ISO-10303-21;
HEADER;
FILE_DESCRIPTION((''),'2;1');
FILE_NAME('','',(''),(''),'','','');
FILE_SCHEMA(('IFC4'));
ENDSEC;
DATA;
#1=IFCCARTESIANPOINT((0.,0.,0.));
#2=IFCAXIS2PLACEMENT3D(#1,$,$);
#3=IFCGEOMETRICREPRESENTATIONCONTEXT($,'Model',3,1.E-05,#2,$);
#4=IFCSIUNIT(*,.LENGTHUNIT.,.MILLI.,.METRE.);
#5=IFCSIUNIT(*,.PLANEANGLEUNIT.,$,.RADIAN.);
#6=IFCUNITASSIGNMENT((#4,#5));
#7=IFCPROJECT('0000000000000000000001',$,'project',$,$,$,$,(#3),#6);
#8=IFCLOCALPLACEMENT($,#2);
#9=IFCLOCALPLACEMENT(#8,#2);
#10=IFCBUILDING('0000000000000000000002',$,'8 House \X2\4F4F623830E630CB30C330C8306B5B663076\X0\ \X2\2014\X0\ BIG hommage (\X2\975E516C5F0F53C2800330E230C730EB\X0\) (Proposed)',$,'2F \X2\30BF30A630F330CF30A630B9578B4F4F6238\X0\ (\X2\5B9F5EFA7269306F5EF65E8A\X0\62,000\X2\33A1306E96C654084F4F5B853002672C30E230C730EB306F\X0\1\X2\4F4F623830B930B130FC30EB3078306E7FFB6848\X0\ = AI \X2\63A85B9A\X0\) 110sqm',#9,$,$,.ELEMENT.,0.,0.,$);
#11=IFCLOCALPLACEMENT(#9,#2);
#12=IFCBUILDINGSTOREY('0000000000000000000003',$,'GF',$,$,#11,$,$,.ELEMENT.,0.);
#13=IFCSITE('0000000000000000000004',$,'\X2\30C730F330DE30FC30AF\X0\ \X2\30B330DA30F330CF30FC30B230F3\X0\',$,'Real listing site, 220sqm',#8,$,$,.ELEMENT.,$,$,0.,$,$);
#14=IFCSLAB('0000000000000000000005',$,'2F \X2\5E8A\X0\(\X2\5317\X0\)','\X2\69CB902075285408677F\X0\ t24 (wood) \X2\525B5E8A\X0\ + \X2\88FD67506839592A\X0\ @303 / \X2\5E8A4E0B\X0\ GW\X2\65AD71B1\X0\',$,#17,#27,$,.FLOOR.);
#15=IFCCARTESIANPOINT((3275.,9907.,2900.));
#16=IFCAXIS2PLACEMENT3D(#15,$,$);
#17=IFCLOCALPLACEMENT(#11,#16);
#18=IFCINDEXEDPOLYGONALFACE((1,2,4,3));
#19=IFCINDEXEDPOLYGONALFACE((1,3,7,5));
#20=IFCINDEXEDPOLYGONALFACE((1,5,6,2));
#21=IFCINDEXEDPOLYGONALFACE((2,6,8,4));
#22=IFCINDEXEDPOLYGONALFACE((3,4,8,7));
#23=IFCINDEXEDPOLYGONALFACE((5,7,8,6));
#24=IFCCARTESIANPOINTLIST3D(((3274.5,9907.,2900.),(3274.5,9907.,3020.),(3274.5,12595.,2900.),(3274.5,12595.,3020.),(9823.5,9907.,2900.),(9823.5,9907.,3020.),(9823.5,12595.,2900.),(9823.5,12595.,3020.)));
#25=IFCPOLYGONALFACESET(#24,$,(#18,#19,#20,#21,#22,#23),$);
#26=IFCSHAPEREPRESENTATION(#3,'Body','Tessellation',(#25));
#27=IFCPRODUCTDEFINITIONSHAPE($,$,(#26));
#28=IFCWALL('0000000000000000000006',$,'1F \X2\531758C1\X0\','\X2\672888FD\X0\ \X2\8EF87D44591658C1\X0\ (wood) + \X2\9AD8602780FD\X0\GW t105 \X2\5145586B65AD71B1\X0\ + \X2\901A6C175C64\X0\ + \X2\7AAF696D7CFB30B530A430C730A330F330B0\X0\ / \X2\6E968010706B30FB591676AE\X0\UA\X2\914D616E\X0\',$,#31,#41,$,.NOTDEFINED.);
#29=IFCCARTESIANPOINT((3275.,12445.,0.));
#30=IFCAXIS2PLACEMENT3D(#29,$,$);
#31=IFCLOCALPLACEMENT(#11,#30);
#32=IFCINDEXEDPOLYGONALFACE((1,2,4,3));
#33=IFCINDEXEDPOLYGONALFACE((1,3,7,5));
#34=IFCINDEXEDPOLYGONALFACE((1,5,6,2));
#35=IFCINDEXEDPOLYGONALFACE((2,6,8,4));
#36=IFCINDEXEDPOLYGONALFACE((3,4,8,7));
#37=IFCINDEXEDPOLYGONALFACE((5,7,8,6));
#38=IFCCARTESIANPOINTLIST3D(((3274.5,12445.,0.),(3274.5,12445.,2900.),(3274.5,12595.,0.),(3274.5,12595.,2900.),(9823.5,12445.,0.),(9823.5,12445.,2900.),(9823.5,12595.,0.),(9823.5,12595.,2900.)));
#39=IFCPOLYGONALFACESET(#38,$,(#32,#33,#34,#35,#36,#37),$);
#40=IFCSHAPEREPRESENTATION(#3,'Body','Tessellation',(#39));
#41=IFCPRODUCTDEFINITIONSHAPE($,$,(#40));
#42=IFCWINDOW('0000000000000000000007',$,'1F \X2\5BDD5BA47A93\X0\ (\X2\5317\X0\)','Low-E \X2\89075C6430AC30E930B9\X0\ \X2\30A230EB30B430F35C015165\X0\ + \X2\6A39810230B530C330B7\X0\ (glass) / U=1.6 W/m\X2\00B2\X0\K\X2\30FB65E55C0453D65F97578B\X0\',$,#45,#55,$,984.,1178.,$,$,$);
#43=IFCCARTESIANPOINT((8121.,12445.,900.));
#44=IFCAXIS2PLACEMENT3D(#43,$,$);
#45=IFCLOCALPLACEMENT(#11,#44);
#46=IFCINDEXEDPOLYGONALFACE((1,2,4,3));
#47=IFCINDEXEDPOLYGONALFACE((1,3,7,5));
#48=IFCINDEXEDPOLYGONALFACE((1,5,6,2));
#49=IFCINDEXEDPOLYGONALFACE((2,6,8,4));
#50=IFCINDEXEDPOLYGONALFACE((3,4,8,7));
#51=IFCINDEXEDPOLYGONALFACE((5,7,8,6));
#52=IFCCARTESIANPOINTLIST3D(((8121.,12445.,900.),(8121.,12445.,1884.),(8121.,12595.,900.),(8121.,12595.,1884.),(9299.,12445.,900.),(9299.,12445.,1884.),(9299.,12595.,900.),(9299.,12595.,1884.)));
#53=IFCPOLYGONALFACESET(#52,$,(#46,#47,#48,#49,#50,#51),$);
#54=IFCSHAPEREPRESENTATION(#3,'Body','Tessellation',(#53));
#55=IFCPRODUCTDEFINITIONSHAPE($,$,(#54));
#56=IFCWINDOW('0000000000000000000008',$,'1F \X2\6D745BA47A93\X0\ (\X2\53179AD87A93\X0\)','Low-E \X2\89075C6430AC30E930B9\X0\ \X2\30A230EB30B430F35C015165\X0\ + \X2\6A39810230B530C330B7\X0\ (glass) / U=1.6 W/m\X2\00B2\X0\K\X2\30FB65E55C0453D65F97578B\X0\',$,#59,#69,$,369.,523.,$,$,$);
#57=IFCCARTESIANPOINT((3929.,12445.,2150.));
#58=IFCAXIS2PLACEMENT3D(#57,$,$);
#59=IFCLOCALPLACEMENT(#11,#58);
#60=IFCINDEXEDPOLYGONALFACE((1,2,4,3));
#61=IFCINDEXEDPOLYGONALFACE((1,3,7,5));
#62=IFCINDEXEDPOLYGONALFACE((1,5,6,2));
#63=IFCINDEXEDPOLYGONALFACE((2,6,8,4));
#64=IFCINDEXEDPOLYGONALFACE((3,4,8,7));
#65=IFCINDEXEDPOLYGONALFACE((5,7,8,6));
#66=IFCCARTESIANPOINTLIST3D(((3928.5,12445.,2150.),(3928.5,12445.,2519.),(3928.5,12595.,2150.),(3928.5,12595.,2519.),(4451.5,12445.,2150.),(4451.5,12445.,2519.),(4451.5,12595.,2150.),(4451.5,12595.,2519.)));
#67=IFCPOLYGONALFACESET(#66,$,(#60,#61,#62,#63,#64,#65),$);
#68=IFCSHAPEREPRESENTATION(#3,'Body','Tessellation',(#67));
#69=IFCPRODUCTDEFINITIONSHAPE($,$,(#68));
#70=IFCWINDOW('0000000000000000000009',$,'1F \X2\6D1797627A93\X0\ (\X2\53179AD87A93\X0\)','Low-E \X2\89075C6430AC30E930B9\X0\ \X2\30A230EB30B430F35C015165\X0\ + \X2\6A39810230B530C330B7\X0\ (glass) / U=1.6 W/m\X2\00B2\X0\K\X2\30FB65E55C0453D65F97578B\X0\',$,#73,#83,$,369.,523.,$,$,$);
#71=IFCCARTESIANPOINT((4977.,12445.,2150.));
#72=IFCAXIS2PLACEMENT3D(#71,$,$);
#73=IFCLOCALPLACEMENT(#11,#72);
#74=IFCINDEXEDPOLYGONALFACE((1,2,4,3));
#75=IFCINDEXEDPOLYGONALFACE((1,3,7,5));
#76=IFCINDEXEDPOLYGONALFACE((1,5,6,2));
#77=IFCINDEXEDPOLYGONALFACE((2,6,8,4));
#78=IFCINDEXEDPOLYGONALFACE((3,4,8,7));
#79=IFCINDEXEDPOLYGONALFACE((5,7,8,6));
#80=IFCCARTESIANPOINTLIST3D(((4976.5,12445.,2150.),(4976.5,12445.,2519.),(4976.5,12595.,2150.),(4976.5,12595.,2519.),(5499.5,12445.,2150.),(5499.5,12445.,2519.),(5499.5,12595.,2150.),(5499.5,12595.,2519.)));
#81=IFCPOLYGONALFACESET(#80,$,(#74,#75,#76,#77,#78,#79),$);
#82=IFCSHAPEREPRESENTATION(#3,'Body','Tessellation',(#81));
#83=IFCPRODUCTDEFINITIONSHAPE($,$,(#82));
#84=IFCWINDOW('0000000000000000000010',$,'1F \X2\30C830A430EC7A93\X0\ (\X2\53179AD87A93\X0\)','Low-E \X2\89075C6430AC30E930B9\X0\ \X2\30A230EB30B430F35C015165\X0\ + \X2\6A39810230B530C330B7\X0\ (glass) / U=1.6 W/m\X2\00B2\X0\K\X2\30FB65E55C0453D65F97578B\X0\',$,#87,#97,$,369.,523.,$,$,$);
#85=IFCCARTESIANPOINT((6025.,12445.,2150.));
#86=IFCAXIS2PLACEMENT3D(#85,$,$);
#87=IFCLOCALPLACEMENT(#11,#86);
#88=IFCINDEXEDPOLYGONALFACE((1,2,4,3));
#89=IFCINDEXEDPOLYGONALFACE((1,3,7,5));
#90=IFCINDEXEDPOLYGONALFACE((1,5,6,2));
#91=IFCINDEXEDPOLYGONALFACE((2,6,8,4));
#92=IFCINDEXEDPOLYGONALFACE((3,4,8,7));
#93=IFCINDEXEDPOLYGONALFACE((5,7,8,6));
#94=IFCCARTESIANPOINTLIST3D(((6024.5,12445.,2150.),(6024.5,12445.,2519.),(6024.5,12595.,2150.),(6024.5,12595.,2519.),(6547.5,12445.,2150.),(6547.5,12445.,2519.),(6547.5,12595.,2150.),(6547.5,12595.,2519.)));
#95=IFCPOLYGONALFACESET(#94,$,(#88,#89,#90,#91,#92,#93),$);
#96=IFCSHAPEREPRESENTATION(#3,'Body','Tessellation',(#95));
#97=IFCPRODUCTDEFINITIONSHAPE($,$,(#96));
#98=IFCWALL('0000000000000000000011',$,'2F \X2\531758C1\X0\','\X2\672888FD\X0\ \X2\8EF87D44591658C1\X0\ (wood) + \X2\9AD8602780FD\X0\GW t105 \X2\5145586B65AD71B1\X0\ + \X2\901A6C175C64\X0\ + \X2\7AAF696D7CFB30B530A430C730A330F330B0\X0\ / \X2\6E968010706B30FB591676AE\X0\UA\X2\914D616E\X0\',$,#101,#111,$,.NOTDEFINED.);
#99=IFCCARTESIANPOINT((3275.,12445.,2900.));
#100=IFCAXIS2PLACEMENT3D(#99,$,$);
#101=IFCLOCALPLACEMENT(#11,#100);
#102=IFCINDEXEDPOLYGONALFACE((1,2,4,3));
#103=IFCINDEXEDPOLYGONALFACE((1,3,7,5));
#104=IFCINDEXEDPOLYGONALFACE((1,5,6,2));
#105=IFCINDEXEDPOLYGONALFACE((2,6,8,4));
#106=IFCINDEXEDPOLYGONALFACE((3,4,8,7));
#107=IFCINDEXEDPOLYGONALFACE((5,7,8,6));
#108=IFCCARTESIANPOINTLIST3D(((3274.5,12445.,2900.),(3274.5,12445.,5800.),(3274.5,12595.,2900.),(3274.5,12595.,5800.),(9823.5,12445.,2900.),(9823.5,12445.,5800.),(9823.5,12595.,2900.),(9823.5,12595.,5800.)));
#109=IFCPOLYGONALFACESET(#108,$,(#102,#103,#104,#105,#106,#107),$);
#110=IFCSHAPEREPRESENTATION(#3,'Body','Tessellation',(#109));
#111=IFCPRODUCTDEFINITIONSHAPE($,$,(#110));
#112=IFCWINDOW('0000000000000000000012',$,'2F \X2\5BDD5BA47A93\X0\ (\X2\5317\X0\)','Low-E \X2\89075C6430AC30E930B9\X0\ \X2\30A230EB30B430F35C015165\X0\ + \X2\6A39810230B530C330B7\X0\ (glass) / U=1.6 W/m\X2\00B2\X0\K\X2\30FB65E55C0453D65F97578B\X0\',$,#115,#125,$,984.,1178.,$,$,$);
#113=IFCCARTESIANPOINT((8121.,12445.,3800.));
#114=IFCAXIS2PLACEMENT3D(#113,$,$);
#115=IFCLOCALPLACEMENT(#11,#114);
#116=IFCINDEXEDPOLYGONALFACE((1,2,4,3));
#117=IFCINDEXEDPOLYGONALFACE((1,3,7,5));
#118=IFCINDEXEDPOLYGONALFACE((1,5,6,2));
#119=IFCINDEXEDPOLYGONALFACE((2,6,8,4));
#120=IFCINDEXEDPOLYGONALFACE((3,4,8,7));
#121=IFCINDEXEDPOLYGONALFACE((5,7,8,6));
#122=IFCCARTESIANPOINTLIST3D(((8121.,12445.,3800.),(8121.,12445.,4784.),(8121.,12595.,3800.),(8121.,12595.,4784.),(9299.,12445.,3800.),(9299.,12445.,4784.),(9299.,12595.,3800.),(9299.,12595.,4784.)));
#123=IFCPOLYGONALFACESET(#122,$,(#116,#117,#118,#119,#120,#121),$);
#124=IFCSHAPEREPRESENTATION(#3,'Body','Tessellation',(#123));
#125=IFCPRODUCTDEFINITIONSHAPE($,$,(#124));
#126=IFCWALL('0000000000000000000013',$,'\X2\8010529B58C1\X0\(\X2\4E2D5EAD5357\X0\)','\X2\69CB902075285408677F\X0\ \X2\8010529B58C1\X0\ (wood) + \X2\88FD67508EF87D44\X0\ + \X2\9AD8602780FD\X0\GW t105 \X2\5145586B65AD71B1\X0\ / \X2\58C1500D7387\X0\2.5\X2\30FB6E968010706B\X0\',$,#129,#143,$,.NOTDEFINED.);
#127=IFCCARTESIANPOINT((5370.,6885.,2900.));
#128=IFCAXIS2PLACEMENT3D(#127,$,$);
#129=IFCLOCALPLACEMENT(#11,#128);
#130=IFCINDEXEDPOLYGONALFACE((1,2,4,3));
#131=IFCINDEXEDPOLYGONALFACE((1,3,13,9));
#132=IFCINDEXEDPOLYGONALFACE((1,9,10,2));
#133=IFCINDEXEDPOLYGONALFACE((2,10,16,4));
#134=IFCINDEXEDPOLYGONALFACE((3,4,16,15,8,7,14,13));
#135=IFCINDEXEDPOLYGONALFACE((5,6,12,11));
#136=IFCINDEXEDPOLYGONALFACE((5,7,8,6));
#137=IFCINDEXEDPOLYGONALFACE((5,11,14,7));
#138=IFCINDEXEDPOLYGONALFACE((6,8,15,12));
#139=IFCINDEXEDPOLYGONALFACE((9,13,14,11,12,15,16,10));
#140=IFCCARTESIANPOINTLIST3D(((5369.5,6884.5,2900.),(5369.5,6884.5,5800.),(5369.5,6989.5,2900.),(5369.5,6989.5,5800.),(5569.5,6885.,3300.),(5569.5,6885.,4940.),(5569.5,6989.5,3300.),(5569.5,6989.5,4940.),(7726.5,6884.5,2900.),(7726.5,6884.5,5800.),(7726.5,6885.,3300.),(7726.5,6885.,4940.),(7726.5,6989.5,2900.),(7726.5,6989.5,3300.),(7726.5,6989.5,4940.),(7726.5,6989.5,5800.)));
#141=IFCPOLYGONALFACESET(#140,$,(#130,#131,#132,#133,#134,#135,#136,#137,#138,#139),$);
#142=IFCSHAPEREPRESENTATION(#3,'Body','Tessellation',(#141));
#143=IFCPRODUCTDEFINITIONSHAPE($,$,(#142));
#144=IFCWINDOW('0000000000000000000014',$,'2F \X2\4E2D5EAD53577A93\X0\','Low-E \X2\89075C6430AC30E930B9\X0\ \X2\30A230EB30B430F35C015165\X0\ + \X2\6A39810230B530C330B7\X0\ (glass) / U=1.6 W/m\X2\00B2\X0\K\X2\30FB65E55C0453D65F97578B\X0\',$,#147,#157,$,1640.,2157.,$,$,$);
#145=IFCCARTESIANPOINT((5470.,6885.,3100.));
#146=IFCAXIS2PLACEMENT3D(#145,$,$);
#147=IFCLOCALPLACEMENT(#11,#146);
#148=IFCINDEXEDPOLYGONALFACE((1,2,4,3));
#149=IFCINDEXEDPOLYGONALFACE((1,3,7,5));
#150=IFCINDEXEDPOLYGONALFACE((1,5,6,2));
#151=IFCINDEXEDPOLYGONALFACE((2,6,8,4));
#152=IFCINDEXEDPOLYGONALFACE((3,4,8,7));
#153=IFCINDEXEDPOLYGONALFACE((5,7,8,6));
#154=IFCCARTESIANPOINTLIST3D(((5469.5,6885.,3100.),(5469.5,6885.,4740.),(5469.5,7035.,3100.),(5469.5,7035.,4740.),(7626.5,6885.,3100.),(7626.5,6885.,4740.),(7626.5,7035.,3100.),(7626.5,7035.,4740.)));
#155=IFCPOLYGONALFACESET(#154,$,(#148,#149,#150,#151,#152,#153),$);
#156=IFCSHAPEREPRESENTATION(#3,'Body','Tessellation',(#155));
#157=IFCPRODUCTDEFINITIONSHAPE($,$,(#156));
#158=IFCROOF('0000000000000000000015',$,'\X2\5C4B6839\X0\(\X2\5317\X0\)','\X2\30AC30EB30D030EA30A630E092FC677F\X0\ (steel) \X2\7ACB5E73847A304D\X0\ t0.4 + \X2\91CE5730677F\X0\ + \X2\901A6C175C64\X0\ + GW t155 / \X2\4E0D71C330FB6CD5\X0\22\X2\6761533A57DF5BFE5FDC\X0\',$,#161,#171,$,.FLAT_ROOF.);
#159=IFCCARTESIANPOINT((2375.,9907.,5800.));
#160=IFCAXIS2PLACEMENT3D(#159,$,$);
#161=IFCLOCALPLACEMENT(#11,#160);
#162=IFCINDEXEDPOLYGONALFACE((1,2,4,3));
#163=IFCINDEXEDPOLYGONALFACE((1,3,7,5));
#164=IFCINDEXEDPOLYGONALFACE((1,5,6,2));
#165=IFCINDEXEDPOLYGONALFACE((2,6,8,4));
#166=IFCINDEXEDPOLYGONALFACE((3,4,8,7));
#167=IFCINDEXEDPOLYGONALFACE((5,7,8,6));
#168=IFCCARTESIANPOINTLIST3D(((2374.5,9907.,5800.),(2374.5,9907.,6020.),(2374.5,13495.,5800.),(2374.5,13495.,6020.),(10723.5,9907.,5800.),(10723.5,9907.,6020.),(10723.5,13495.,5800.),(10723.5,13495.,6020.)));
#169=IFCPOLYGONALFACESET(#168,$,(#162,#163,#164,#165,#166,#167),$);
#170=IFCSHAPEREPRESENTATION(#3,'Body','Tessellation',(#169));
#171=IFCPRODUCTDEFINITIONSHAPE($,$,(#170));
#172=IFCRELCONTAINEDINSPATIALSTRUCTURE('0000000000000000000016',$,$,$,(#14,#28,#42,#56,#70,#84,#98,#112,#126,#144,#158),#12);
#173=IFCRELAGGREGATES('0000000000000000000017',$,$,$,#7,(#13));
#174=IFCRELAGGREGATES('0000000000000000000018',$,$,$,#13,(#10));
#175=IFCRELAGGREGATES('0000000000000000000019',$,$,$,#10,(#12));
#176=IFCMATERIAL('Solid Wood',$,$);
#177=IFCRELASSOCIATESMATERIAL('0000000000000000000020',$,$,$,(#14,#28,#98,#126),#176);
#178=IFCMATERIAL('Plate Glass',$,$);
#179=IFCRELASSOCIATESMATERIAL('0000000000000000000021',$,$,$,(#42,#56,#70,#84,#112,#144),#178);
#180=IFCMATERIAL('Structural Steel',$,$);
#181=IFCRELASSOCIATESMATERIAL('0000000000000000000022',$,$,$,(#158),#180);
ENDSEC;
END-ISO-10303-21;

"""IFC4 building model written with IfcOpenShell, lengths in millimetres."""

from ifc_helpers import new_model, si_unit, frame, frame_2d, origin, place, context, project, spatial, rectangle, extrude, material, element, fill, save


model = new_model("IFC4")

# Units and contexts
model_context = context("Model", 3, precision=1e-05, world=origin())
ifc_project = project(units=[si_unit("LENGTHUNIT", "METRE", prefix="MILLI"), si_unit("PLANEANGLEUNIT", "RADIAN")], contexts=[model_context])

# Site, building, storey
site_placement = place(None, origin())
site = spatial("IfcSite", under=ifc_project, at=site_placement, Name="デンマーク コペンハーゲン", ObjectType="Real listing site, 220sqm", CompositionType="ELEMENT", RefElevation=0.0)
building_placement = place(site_placement, origin())
building = spatial("IfcBuilding", under=site, at=building_placement, Name="8 House 住戸ユニットに学ぶ — BIG hommage (非公式参考モデル) (Proposed)", ObjectType="2F タウンハウス型住戸 (実建物は延床62,000㎡の集合住宅。本モデルは1住戸スケールへの翻案 = AI 推定) 110sqm", CompositionType="ELEMENT", ElevationOfRefHeight=0.0, ElevationOfTerrain=0.0)
storey_placement = place(building_placement, origin())
storey = spatial("IfcBuildingStorey", under=building, at=storey_placement, Name="GF", CompositionType="ELEMENT", Elevation=0.0)

# Slab
ifc_material_1 = material(Name="Solid Wood")
slab_1_placement = place(storey_placement, frame((3275.0, 9907.0, 2900.0)))
element("IfcSlab", 1, at=slab_1_placement, inside=storey, material=ifc_material_1, Name="2F 床(北)", Description="構造用合板 t24 (wood) 剛床 + 製材根太 @303 / 床下 GW断熱", PredefinedType="FLOOR", context=model_context, shape_type="SweptSolid", body=[
    extrude(rectangle(XDim=6549.0, YDim=2688.0, at=frame_2d((3274.0, 1344.0))), frame((3275.0, 9907.0, 2900.0)), (0.0, 0.0, 1.0), 120.0),
])

# Wall, openings, windows
wall_1_placement = place(storey_placement, frame((3275.0, 12445.0, 0.0)))
wall_1 = element("IfcWall", 2, at=wall_1_placement, inside=storey, material=ifc_material_1, Name="1F 北壁", Description="木製 軸組外壁 (wood) + 高性能GW t105 充填断熱 + 通気層 + 窯業系サイディング / 準耐火・外皮UA配慮", PredefinedType="NOTDEFINED", context=model_context, shape_type="SweptSolid", body=[
    extrude(rectangle(XDim=6549.0, YDim=150.0, at=frame_2d((3274.0, 75.0))), frame((3275.0, 12445.0, 0.0)), (0.0, 0.0, 1.0), 2900.0),
])
opening_1_placement = place(storey_placement, frame((8121.0, 12445.0, 900.0)))
opening_1 = element("IfcOpeningElement", 3, at=opening_1_placement, cuts=wall_1, PredefinedType="NOTDEFINED", context=model_context, shape_type="SweptSolid", body=[
    extrude(rectangle(XDim=1178.0, YDim=150.0, at=frame_2d((589.0, 75.0))), frame((8121.0, 12445.0, 900.0)), (0.0, 0.0, 1.0), 984.0),
])
opening_2_placement = place(storey_placement, frame((3929.0, 12445.0, 2150.0)))
opening_2 = element("IfcOpeningElement", 4, at=opening_2_placement, cuts=wall_1, PredefinedType="NOTDEFINED", context=model_context, shape_type="SweptSolid", body=[
    extrude(rectangle(XDim=523.0, YDim=150.0, at=frame_2d((261.0, 75.0))), frame((3929.0, 12445.0, 2150.0)), (0.0, 0.0, 1.0), 369.0),
])
opening_3_placement = place(storey_placement, frame((4977.0, 12445.0, 2150.0)))
opening_3 = element("IfcOpeningElement", 5, at=opening_3_placement, cuts=wall_1, PredefinedType="NOTDEFINED", context=model_context, shape_type="SweptSolid", body=[
    extrude(rectangle(XDim=523.0, YDim=150.0, at=frame_2d((261.0, 75.0))), frame((4977.0, 12445.0, 2150.0)), (0.0, 0.0, 1.0), 369.0),
])
opening_4_placement = place(storey_placement, frame((6025.0, 12445.0, 2150.0)))
opening_4 = element("IfcOpeningElement", 6, at=opening_4_placement, cuts=wall_1, PredefinedType="NOTDEFINED", context=model_context, shape_type="SweptSolid", body=[
    extrude(rectangle(XDim=523.0, YDim=150.0, at=frame_2d((261.0, 75.0))), frame((6025.0, 12445.0, 2150.0)), (0.0, 0.0, 1.0), 369.0),
])
ifc_material_2 = material(Name="Plate Glass")
window_1_placement = place(storey_placement, frame((8121.0, 12445.0, 900.0)))
window_1 = element("IfcWindow", 7, at=window_1_placement, inside=storey, material=ifc_material_2, Name="1F 寝室窓 (北)", Description="Low-E 複層ガラス アルゴン封入 + 樹脂サッシ (glass) / U=1.6 W/m²K・日射取得型", OverallHeight=984.0, OverallWidth=1178.0, context=model_context, shape_type="SweptSolid", body=[
    extrude(rectangle(XDim=1178.0, YDim=150.0, at=frame_2d((589.0, 75.0))), frame((8121.0, 12445.0, 900.0)), (0.0, 0.0, 1.0), 984.0),
])
fill(opening_1, window_1)
window_2_placement = place(storey_placement, frame((3929.0, 12445.0, 2150.0)))
window_2 = element("IfcWindow", 8, at=window_2_placement, inside=storey, material=ifc_material_2, Name="1F 浴室窓 (北高窓)", Description="Low-E 複層ガラス アルゴン封入 + 樹脂サッシ (glass) / U=1.6 W/m²K・日射取得型", OverallHeight=369.0, OverallWidth=523.0, context=model_context, shape_type="SweptSolid", body=[
    extrude(rectangle(XDim=523.0, YDim=150.0, at=frame_2d((261.0, 75.0))), frame((3929.0, 12445.0, 2150.0)), (0.0, 0.0, 1.0), 369.0),
])
fill(opening_2, window_2)
window_3_placement = place(storey_placement, frame((4977.0, 12445.0, 2150.0)))
window_3 = element("IfcWindow", 9, at=window_3_placement, inside=storey, material=ifc_material_2, Name="1F 洗面窓 (北高窓)", Description="Low-E 複層ガラス アルゴン封入 + 樹脂サッシ (glass) / U=1.6 W/m²K・日射取得型", OverallHeight=369.0, OverallWidth=523.0, context=model_context, shape_type="SweptSolid", body=[
    extrude(rectangle(XDim=523.0, YDim=150.0, at=frame_2d((261.0, 75.0))), frame((4977.0, 12445.0, 2150.0)), (0.0, 0.0, 1.0), 369.0),
])
fill(opening_3, window_3)
window_4_placement = place(storey_placement, frame((6025.0, 12445.0, 2150.0)))
window_4 = element("IfcWindow", 10, at=window_4_placement, inside=storey, material=ifc_material_2, Name="1F トイレ窓 (北高窓)", Description="Low-E 複層ガラス アルゴン封入 + 樹脂サッシ (glass) / U=1.6 W/m²K・日射取得型", OverallHeight=369.0, OverallWidth=523.0, context=model_context, shape_type="SweptSolid", body=[
    extrude(rectangle(XDim=523.0, YDim=150.0, at=frame_2d((261.0, 75.0))), frame((6025.0, 12445.0, 2150.0)), (0.0, 0.0, 1.0), 369.0),
])
fill(opening_4, window_4)

# Walls, openings, windows
wall_2_placement = place(storey_placement, frame((3275.0, 12445.0, 2900.0)))
wall_2 = element("IfcWall", 11, at=wall_2_placement, inside=storey, material=ifc_material_1, Name="2F 北壁", Description="木製 軸組外壁 (wood) + 高性能GW t105 充填断熱 + 通気層 + 窯業系サイディング / 準耐火・外皮UA配慮", PredefinedType="NOTDEFINED", context=model_context, shape_type="SweptSolid", body=[
    extrude(rectangle(XDim=6549.0, YDim=150.0, at=frame_2d((3274.0, 75.0))), frame((3275.0, 12445.0, 2900.0)), (0.0, 0.0, 1.0), 2900.0),
])
opening_5_placement = place(storey_placement, frame((8121.0, 12445.0, 3800.0)))
opening_5 = element("IfcOpeningElement", 12, at=opening_5_placement, cuts=wall_2, PredefinedType="NOTDEFINED", context=model_context, shape_type="SweptSolid", body=[
    extrude(rectangle(XDim=1178.0, YDim=150.0, at=frame_2d((589.0, 75.0))), frame((8121.0, 12445.0, 3800.0)), (0.0, 0.0, 1.0), 984.0),
])
window_5_placement = place(storey_placement, frame((8121.0, 12445.0, 3800.0)))
window_5 = element("IfcWindow", 13, at=window_5_placement, inside=storey, material=ifc_material_2, Name="2F 寝室窓 (北)", Description="Low-E 複層ガラス アルゴン封入 + 樹脂サッシ (glass) / U=1.6 W/m²K・日射取得型", OverallHeight=984.0, OverallWidth=1178.0, context=model_context, shape_type="SweptSolid", body=[
    extrude(rectangle(XDim=1178.0, YDim=150.0, at=frame_2d((589.0, 75.0))), frame((8121.0, 12445.0, 3800.0)), (0.0, 0.0, 1.0), 984.0),
])
fill(opening_5, window_5)
wall_3_placement = place(storey_placement, frame((5370.0, 6885.0, 2900.0)))
wall_3 = element("IfcWall", 14, at=wall_3_placement, inside=storey, material=ifc_material_1, Name="耐力壁(中庭南)", Description="構造用合板 耐力壁 (wood) + 製材軸組 + 高性能GW t105 充填断熱 / 壁倍率2.5・準耐火", PredefinedType="NOTDEFINED", context=model_context, shape_type="SweptSolid", body=[
    extrude(rectangle(XDim=2357.0, YDim=105.0, at=frame_2d((1178.0, 52.0))), frame((5370.0, 6885.0, 2900.0)), (0.0, 0.0, 1.0), 2900.0),
])
opening_6_placement = place(storey_placement, frame((5470.0, 6885.0, 3100.0)))
opening_6 = element("IfcOpeningElement", 15, at=opening_6_placement, cuts=wall_3, PredefinedType="NOTDEFINED", context=model_context, shape_type="SweptSolid", body=[
    extrude(rectangle(XDim=2157.0, YDim=150.0, at=frame_2d((1078.0, 75.0))), frame((5470.0, 6885.0, 3100.0)), (0.0, 0.0, 1.0), 1640.0),
])
window_6_placement = place(storey_placement, frame((5470.0, 6885.0, 3100.0)))
window_6 = element("IfcWindow", 16, at=window_6_placement, inside=storey, material=ifc_material_2, Name="2F 中庭南窓", Description="Low-E 複層ガラス アルゴン封入 + 樹脂サッシ (glass) / U=1.6 W/m²K・日射取得型", OverallHeight=1640.0, OverallWidth=2157.0, context=model_context, shape_type="SweptSolid", body=[
    extrude(rectangle(XDim=2157.0, YDim=150.0, at=frame_2d((1078.0, 75.0))), frame((5470.0, 6885.0, 3100.0)), (0.0, 0.0, 1.0), 1640.0),
])
fill(opening_6, window_6)

# Roof
ifc_material_3 = material(Name="Structural Steel")
for number, where, name in (
    (17, (2375.0, 9907.0, 5800.0), "屋根(北)"),
):
    element("IfcRoof", number, at=place(storey_placement, frame(where)), inside=storey, material=ifc_material_3, Name=name, Description="ガルバリウム鋼板 (steel) 立平葺き t0.4 + 野地板 + 通気層 + GW t155 / 不燃・法22条区域対応", PredefinedType="FLAT_ROOF", context=model_context, shape_type="SweptSolid", body=[
        extrude(rectangle(XDim=8349.0, YDim=3588.0, at=frame_2d((4174.0, 1794.0))), frame((2375.0, 9907.0, 5800.0)), (0.0, 0.0, 1.0), 220.0),
    ])

save(model, "model.ifc")
